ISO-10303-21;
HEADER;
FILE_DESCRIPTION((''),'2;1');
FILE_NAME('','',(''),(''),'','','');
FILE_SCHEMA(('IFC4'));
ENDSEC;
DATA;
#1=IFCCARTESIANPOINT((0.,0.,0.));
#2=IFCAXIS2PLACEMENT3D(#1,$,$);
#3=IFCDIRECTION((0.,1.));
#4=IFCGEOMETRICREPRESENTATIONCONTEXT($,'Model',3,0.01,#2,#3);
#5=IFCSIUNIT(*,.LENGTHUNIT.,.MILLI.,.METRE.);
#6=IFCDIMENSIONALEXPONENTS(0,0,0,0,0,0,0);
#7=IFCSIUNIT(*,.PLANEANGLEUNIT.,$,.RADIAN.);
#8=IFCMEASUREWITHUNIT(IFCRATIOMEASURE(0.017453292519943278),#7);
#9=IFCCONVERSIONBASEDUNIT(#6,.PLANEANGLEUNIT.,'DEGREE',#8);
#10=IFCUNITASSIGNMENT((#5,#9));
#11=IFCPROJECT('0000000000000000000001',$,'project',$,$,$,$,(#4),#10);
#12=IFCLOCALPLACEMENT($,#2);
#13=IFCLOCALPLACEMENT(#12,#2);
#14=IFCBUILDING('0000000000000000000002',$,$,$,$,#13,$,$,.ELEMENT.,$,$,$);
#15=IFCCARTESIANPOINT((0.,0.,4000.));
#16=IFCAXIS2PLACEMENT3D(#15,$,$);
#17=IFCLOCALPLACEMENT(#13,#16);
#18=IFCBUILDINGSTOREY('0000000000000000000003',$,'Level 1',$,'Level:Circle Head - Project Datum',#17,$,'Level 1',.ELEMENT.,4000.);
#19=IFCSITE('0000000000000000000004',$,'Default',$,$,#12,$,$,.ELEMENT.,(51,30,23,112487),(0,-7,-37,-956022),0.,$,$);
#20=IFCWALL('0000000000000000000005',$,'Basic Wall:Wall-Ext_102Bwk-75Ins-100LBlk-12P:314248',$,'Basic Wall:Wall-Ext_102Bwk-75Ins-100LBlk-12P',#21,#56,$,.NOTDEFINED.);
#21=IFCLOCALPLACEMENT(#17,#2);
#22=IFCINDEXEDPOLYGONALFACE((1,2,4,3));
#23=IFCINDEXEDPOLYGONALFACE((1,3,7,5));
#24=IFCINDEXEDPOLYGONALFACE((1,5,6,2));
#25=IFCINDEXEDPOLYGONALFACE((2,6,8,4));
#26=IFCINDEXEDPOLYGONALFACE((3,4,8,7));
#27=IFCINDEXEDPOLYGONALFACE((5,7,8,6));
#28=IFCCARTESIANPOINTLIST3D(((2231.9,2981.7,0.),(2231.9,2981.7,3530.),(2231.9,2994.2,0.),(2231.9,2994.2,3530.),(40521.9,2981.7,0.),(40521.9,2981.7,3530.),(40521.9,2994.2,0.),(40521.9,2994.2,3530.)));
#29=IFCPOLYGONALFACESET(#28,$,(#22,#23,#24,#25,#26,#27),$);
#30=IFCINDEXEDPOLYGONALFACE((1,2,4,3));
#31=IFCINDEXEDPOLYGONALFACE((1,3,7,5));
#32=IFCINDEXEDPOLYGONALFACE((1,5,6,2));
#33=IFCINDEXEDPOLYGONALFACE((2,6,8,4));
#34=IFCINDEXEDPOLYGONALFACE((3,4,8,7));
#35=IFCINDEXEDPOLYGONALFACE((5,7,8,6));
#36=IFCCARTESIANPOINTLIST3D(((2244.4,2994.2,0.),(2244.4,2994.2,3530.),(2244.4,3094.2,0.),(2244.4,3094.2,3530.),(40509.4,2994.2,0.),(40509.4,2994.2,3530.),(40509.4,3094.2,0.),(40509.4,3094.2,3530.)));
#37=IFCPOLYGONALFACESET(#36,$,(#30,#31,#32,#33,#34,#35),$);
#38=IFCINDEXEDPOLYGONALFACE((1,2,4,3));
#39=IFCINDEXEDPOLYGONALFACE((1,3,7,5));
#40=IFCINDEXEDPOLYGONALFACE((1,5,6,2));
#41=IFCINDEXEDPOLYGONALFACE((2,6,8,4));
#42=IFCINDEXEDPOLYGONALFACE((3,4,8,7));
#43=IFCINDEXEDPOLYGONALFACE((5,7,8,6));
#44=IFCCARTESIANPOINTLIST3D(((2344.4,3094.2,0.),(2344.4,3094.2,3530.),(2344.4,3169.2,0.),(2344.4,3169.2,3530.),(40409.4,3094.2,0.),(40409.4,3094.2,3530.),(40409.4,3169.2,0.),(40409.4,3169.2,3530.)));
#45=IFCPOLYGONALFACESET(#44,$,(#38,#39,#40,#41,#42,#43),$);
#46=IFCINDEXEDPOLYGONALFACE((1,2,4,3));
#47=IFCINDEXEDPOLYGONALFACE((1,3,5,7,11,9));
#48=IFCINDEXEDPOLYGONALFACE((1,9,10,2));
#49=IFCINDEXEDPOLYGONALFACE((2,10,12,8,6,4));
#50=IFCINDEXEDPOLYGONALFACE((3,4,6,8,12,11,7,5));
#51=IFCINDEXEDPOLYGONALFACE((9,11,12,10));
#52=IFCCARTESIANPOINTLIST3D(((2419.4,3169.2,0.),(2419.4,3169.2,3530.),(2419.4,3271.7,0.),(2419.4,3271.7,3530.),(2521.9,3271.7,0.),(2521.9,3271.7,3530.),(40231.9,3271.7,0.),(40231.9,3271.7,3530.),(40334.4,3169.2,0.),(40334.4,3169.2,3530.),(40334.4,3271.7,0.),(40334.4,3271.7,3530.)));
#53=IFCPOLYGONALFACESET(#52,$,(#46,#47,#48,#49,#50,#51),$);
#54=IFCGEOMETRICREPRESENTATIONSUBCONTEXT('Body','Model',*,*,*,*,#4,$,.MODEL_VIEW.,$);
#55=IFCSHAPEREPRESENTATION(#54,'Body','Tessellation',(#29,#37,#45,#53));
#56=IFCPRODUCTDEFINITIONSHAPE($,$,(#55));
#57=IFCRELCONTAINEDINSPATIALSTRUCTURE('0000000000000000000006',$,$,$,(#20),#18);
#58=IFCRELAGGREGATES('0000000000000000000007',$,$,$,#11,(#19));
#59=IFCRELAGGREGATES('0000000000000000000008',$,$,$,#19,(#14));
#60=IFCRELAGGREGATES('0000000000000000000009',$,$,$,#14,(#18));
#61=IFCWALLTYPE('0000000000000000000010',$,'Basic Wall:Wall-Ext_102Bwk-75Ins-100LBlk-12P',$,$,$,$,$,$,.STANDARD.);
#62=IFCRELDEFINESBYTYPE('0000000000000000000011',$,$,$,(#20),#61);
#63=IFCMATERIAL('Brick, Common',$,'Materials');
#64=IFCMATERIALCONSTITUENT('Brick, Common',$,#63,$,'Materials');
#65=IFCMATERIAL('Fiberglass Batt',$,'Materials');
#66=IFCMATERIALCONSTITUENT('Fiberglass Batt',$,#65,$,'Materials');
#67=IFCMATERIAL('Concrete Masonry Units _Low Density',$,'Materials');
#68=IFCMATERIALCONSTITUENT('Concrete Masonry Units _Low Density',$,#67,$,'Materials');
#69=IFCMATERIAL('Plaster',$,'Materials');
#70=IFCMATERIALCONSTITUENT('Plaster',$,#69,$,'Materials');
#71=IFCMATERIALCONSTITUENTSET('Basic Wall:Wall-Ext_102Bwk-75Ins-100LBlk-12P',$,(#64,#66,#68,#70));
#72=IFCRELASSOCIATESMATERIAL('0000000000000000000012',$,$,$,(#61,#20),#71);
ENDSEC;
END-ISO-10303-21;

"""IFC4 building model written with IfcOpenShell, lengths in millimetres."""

from ifc_helpers import new_model, entity, si_unit, converted_unit, direction, frame, origin, place, context, subcontext, project, spatial, indexed_curve, outline, extrude, material, constituent, constituent_set, type_object, element, save


model = new_model("IFC4")

# Units and contexts
model_context = context("Model", 3, precision=0.01, world=origin(), true_north=direction((0.0, 1.0)))
body_context = subcontext(model_context, "Body", "Model", "MODEL_VIEW")
ifc_project = project(units=[si_unit("LENGTHUNIT", "METRE", prefix="MILLI"), converted_unit("PLANEANGLEUNIT", "DEGREE", entity("IfcRatioMeasure", 0.017453292519943278), si_unit("PLANEANGLEUNIT", "RADIAN"), dimensions=[0, 0, 0, 0, 0, 0, 0])], contexts=[model_context])

# Site, building, storey
site_placement = place(None, origin())
site = spatial("IfcSite", under=ifc_project, at=site_placement, Name="Default", CompositionType="ELEMENT", RefLatitude=(51, 30, 23, 112487), RefLongitude=(0, -7, -37, -956022), RefElevation=0.0)
building_placement = place(site_placement, origin())
building = spatial("IfcBuilding", under=site, at=building_placement, CompositionType="ELEMENT")
storey_placement = place(building_placement, frame((0.0, 0.0, 4000.0)))
storey = spatial("IfcBuildingStorey", under=building, at=storey_placement, Name="Level 1", ObjectType="Level:Circle Head - Project Datum", LongName="Level 1", CompositionType="ELEMENT", Elevation=4000.0)

# Wall
ifc_material_1 = material(Name="Brick, Common", Category="Materials")
ifc_constituent_1 = constituent(ifc_material_1, Name="Brick, Common", Category="Materials")
ifc_material_2 = material(Name="Fiberglass Batt", Category="Materials")
ifc_constituent_2 = constituent(ifc_material_2, Name="Fiberglass Batt", Category="Materials")
ifc_material_3 = material(Name="Concrete Masonry Units _Low Density", Category="Materials")
ifc_constituent_3 = constituent(ifc_material_3, Name="Concrete Masonry Units _Low Density", Category="Materials")
ifc_material_4 = material(Name="Plaster", Category="Materials")
ifc_constituent_4 = constituent(ifc_material_4, Name="Plaster", Category="Materials")
ifc_constituent_set_1 = constituent_set(constituents=[ifc_constituent_1, ifc_constituent_2, ifc_constituent_3, ifc_constituent_4], Name="Basic Wall:Wall-Ext_102Bwk-75Ins-100LBlk-12P")
wall_type = type_object("IfcWallType", Name="Basic Wall:Wall-Ext_102Bwk-75Ins-100LBlk-12P", PredefinedType="STANDARD", material=ifc_constituent_set_1)
wall_1_placement = place(storey_placement, frame((2231.9, 3126.7, 0.0)))
element("IfcWall", 1, at=wall_1_placement, inside=storey, type_object=wall_type, material=ifc_constituent_set_1, Name="Basic Wall:Wall-Ext_102Bwk-75Ins-100LBlk-12P:314248", ObjectType="Basic Wall:Wall-Ext_102Bwk-75Ins-100LBlk-12P", PredefinedType="NOTDEFINED", context=body_context, shape_type="SweptSolid", body=[
    extrude(outline(indexed_curve([(-6.3, -19145.0), (6.2, -19145.0), (6.3, 19145.0), (-6.2, 19145.0), (-6.3, -19145.0)], self_intersect=False)), frame((19145.0, -138.7, 0.0), z_axis=(0.0, 0.0, 1.0), x_axis=(0.0, 1.0, 0.0)), (0.0, 0.0, 1.0), 3530.0),
    extrude(outline(indexed_curve([(-19132.5, -50.0), (19132.5, -50.0), (19132.5, 50.0), (-19132.5, 50.0), (-19132.5, -50.0)], self_intersect=False)), frame((19145.0, -82.5, 0.0)), (0.0, 0.0, 1.0), 3530.0),
    extrude(outline(indexed_curve([(-19032.5, -37.5), (19032.5, -37.5), (19032.5, 37.5), (-19032.5, 37.5), (-19032.5, -37.5)], self_intersect=False)), frame((19145.0, 5.0, 0.0)), (0.0, 0.0, 1.0), 3530.0),
    extrude(outline(indexed_curve([(-18855.0, -34.2), (18855.0, -34.2), (18957.5, -34.2), (18957.5, 68.3), (-18957.5, 68.3), (-18957.5, -34.2), (-18855.0, -34.2)], self_intersect=False)), frame((19145.0, 110.8, 0.0), z_axis=(0.0, 0.0, 1.0), x_axis=(-1.0, 0.0, 0.0)), (0.0, 0.0, 1.0), 3530.0),
])

save(model, "model.ifc")
